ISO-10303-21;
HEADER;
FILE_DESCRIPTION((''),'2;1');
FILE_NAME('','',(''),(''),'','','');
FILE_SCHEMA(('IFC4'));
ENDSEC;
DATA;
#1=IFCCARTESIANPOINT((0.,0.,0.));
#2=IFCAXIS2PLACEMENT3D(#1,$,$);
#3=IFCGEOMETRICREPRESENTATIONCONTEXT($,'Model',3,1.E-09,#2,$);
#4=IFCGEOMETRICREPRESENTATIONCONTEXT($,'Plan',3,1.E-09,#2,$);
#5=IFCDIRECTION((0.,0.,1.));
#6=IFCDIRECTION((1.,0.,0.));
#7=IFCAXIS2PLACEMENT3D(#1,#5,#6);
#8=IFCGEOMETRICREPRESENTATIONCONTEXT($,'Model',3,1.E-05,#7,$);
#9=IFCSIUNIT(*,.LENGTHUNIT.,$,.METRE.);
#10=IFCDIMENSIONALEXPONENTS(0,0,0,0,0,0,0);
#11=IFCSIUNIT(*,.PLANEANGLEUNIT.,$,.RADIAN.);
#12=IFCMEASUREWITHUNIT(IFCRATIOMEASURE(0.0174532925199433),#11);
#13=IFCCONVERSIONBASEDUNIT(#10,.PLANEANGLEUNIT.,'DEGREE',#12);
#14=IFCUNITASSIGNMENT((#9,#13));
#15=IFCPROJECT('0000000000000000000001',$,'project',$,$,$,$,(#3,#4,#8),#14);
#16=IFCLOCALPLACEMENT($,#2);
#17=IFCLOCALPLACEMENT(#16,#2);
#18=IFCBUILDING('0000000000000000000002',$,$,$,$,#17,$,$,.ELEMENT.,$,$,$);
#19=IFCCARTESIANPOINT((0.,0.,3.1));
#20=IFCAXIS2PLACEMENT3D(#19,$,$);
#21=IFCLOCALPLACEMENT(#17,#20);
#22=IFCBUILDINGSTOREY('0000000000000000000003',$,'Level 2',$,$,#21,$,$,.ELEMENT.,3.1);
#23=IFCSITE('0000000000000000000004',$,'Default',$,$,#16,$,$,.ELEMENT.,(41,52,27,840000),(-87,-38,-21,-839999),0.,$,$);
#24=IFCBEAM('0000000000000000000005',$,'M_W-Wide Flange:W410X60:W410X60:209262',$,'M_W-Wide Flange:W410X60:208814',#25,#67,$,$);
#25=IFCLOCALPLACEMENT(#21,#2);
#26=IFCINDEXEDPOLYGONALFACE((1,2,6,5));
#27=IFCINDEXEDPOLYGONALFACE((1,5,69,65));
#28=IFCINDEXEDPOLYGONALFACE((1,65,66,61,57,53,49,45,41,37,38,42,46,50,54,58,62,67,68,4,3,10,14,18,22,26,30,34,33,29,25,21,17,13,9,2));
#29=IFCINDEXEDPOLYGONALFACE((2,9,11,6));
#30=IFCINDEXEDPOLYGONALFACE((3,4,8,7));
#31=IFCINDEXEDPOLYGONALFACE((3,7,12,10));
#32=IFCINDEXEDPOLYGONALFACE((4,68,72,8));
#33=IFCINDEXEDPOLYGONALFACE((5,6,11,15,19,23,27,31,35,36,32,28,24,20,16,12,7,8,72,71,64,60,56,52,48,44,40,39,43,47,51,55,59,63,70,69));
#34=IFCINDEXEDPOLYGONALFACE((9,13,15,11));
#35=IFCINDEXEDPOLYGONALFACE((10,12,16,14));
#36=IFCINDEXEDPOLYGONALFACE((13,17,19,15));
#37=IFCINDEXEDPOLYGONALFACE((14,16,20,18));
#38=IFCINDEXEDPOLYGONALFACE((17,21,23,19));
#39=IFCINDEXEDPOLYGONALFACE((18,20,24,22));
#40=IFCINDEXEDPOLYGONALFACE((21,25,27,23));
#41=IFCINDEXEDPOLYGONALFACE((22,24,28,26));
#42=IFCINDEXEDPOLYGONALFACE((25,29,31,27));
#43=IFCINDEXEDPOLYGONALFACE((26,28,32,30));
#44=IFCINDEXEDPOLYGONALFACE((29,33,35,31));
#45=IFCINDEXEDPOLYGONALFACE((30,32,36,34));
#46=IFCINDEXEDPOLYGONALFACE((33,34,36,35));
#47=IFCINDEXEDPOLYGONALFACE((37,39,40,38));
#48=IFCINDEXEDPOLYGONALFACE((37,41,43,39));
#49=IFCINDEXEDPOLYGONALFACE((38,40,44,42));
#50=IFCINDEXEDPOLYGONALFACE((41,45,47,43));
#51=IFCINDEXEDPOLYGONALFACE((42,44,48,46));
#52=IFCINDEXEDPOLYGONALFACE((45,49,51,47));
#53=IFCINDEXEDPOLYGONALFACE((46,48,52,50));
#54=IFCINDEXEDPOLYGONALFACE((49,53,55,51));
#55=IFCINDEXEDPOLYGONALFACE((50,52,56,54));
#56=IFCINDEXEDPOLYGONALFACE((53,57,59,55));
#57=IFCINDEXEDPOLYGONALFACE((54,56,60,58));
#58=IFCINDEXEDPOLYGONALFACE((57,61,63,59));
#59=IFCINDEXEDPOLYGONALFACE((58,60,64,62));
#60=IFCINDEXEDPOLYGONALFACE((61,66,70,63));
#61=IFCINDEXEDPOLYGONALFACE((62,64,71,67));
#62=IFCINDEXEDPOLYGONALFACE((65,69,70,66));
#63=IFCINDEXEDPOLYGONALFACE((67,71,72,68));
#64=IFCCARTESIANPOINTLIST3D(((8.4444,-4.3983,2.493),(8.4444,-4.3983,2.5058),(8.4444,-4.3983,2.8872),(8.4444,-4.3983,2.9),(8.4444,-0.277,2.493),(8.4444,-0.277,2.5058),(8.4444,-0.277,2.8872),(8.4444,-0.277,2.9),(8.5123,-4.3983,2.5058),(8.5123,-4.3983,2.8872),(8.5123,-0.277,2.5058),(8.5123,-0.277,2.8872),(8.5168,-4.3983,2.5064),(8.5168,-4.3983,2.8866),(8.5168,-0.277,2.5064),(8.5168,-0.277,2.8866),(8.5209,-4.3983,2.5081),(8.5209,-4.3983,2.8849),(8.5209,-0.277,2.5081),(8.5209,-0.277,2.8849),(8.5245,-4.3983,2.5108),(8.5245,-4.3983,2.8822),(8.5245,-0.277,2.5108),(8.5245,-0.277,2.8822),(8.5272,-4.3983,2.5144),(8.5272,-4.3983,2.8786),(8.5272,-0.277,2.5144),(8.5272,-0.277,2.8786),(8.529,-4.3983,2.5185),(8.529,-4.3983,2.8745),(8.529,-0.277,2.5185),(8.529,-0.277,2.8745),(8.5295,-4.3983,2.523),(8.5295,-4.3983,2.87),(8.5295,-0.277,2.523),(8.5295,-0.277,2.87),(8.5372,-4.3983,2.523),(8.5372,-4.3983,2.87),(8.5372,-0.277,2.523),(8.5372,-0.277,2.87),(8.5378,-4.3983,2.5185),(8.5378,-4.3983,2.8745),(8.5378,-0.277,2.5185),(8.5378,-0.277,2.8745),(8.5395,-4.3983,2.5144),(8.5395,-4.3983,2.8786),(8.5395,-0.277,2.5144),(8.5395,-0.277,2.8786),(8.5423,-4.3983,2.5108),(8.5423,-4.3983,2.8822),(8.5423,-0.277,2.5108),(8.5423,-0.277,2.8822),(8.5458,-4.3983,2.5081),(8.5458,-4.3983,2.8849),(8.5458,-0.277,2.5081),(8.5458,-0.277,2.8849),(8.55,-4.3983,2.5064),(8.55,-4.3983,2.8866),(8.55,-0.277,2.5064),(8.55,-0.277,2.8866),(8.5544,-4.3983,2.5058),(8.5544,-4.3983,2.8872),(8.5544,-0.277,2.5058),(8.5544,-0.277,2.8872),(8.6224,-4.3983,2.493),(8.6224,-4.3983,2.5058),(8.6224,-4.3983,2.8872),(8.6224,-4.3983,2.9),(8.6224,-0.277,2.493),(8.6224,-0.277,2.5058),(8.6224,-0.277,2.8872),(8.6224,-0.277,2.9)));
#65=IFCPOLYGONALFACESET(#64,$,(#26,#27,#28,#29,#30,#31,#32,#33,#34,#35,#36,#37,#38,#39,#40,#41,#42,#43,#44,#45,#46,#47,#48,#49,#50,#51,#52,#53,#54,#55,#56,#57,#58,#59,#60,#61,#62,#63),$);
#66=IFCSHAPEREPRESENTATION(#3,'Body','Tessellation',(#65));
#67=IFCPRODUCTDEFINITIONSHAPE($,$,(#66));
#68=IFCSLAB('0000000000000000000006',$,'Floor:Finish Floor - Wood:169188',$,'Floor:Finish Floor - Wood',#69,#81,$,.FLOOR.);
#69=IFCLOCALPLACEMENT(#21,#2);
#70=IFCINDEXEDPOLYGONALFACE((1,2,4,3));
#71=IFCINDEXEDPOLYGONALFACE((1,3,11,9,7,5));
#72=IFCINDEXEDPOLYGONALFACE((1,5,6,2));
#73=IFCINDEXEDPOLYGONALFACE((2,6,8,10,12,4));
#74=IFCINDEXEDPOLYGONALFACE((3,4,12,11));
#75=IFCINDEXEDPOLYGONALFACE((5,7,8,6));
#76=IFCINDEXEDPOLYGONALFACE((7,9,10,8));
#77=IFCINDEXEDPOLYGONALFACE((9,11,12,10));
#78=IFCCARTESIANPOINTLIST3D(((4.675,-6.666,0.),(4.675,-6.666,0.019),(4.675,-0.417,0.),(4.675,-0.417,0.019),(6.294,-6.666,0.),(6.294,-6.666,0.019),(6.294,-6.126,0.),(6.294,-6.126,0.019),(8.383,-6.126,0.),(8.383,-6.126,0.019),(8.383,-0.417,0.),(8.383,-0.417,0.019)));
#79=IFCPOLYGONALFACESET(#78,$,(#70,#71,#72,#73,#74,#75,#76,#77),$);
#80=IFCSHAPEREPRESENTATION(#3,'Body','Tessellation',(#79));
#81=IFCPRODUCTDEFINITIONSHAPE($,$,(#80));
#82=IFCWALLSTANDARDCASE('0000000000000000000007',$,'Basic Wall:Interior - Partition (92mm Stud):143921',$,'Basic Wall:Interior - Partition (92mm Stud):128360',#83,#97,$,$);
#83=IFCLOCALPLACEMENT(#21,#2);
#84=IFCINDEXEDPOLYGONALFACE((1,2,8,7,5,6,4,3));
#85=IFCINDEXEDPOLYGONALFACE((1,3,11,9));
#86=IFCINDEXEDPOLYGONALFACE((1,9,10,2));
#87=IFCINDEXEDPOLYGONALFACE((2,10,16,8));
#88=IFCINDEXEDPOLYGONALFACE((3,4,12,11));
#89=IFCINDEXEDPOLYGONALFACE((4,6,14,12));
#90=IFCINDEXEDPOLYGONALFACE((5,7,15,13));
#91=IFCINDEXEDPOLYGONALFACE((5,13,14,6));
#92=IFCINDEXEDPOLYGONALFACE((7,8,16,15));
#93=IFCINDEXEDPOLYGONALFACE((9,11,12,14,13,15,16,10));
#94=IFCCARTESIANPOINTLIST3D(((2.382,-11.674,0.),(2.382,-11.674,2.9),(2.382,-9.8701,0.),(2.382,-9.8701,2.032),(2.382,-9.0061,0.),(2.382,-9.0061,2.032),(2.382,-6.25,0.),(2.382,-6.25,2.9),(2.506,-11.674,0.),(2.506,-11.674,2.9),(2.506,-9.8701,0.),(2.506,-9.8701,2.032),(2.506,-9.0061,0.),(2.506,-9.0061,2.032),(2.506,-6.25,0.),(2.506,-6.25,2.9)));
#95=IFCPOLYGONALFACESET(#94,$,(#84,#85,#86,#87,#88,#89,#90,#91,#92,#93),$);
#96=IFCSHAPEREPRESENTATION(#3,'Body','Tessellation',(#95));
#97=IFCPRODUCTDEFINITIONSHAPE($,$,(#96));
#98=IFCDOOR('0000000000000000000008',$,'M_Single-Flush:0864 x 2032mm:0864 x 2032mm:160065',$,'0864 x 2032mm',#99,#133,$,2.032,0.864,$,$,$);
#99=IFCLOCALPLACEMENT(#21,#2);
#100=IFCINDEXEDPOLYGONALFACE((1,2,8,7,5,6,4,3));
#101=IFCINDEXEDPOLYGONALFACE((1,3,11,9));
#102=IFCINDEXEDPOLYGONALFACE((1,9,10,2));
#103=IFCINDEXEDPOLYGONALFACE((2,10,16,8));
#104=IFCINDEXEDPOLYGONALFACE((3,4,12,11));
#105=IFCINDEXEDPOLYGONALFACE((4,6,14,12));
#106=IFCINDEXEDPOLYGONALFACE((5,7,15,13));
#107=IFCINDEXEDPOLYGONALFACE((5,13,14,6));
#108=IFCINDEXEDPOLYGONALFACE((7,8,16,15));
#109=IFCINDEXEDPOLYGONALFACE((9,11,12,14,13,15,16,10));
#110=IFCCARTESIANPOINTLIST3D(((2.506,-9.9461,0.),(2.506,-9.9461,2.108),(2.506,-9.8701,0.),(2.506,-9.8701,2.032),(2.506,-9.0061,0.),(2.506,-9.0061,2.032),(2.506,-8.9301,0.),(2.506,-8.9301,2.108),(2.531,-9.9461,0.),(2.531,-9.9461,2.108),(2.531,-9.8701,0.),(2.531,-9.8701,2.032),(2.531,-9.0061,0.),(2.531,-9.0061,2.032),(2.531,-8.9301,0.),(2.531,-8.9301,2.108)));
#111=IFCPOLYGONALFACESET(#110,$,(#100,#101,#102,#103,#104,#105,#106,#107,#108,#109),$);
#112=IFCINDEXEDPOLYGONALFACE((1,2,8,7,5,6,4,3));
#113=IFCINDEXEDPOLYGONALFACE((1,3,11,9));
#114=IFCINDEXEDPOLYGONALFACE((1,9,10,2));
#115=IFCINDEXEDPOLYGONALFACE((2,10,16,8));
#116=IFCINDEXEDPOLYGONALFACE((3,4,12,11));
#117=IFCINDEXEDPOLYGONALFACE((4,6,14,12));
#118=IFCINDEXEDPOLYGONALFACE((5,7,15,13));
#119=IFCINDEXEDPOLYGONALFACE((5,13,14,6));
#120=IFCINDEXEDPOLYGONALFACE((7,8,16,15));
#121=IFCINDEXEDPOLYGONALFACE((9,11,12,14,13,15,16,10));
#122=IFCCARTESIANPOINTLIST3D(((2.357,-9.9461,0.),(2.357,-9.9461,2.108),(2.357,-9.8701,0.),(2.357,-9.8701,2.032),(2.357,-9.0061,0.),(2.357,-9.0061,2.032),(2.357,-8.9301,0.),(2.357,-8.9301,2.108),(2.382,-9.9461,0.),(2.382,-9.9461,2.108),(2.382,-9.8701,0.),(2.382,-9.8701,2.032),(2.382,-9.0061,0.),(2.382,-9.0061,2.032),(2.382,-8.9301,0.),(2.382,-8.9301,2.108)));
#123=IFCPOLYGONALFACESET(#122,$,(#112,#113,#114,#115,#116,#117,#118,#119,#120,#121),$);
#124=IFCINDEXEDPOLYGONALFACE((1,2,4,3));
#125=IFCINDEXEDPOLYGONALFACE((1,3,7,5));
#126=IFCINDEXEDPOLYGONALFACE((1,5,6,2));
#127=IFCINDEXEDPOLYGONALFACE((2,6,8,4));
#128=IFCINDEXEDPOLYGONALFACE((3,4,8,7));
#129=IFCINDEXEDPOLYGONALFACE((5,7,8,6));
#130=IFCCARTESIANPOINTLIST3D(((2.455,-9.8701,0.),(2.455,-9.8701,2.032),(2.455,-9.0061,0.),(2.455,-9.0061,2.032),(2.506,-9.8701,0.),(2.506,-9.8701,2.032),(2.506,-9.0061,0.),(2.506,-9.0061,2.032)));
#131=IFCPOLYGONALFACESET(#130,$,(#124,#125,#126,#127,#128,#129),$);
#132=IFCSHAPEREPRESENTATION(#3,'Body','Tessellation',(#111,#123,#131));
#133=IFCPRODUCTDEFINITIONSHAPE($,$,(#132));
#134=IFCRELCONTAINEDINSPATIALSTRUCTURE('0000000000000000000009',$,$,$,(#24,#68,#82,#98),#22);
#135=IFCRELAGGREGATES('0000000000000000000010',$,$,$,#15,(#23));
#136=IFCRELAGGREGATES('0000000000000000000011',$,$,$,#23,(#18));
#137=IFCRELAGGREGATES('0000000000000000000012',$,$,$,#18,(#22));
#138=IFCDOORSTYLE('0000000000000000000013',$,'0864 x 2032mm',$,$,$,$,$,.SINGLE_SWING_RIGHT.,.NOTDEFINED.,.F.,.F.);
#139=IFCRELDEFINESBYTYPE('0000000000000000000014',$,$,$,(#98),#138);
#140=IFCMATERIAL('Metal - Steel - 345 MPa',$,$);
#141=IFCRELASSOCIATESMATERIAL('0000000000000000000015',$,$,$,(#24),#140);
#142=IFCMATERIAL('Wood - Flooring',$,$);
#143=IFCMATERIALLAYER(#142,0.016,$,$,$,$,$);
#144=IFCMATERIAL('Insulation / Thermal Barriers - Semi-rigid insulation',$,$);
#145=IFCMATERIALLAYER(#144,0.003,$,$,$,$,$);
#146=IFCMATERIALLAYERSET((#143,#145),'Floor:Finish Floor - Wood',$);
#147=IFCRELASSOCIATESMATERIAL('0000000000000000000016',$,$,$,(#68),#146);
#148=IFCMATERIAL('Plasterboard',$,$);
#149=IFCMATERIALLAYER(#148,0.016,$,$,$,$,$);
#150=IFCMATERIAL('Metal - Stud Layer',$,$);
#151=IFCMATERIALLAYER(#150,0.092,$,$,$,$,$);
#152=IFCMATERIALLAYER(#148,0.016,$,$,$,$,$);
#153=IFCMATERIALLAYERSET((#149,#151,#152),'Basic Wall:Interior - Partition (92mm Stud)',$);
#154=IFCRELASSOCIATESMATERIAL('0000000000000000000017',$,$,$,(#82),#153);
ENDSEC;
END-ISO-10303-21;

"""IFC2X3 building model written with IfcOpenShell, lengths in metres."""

from ifc_helpers import new_model, entity, si_unit, converted_unit, frame, frame_2d, origin, origin_with_axes, origin_2d_with_axis, place, context, project, spatial, polyline, circle_curve, parameter, trimmed, segment, composite_curve, rectangle, outline, extrude, source, transform, mapped, material, layer, layer_set, layer_usage, type_object, type_shapes, element, fill, save


model = new_model("IFC2X3")

# Units and contexts
model_context_1 = context("Model", 3, precision=1e-09, world=origin())
plan_context = context("Plan", 3, precision=1e-09, world=origin())
model_context_2 = context("Model", 3, precision=1e-05, world=origin_with_axes())
ifc_project = project(units=[si_unit("LENGTHUNIT", "METRE"), converted_unit("PLANEANGLEUNIT", "DEGREE", entity("IfcRatioMeasure", 0.0174532925199433), si_unit("PLANEANGLEUNIT", "RADIAN"), dimensions=[0, 0, 0, 0, 0, 0, 0])], contexts=[model_context_1, plan_context, model_context_2])

# Site, building, storey
site_placement = place(None, origin())
site = spatial("IfcSite", under=ifc_project, at=site_placement, Name="Default", CompositionType="ELEMENT", RefLatitude=(41, 52, 27, 840000), RefLongitude=(-87, -38, -21, -839999), RefElevation=0.0)
building_placement = place(site_placement, origin())
building = spatial("IfcBuilding", under=site, at=building_placement, CompositionType="ELEMENT")
storey_placement = place(building_placement, frame((0.0, 0.0, 3.1)))
storey = spatial("IfcBuildingStorey", under=building, at=storey_placement, Name="Level 2", CompositionType="ELEMENT", Elevation=3.1)

# Beam
ifc_material_1 = material(Name="Metal - Steel - 345 MPa")
beam_1_placement = place(storey_placement, frame((8.5334, -4.3983, 2.9)))
element("IfcBeam", 1, at=beam_1_placement, inside=storey, material=ifc_material_1, Name="M_W-Wide Flange:W410X60:W410X60:209262", ObjectType="M_W-Wide Flange:W410X60:208814", context=model_context_1, shape_type="SweptSolid", body=[
    extrude(outline(composite_curve([segment(polyline([(-0.089, -0.1907), (-0.089, -0.2035)]), True, "CONTINUOUS"), segment(polyline([(-0.089, -0.2035), (0.089, -0.2035)]), True, "CONTINUOUS"), segment(polyline([(0.089, -0.2035), (0.089, -0.1907)]), True, "CONTINUOUS"), segment(polyline([(0.089, -0.1907), (0.021, -0.1907)]), True, "CONTINUOUS"), segment(trimmed(circle_curve(frame_2d((0.021, -0.1735), x_axis=(0.0, -1.0)), 0.0172), [parameter(270.0)], [parameter(360.0)], True, "PARAMETER"), False, "CONTINUOUS"), segment(polyline([(0.0038, -0.1735), (0.0038, 0.1735)]), True, "CONTINUOUS"), segment(trimmed(circle_curve(frame_2d((0.021, 0.1735), x_axis=(-1.0, 0.0)), 0.0172), [parameter(270.0)], [parameter(360.0)], True, "PARAMETER"), False, "CONTINUOUS"), segment(polyline([(0.021, 0.1907), (0.089, 0.1907)]), True, "CONTINUOUS"), segment(polyline([(0.089, 0.1907), (0.089, 0.2035)]), True, "CONTINUOUS"), segment(polyline([(0.089, 0.2035), (-0.089, 0.2035)]), True, "CONTINUOUS"), segment(polyline([(-0.089, 0.2035), (-0.089, 0.1907)]), True, "CONTINUOUS"), segment(polyline([(-0.089, 0.1907), (-0.0211, 0.1907)]), True, "CONTINUOUS"), segment(trimmed(circle_curve(frame_2d((-0.0211, 0.1735), x_axis=(0.0, 1.0)), 0.0172), [parameter(270.0)], [parameter(0.0)], True, "PARAMETER"), False, "CONTINUOUS"), segment(polyline([(-0.0039, 0.1735), (-0.0039, -0.1735)]), True, "CONTINUOUS"), segment(trimmed(circle_curve(frame_2d((-0.0211, -0.1735), x_axis=(1.0, 0.0)), 0.0172), [parameter(270.0)], [parameter(0.0)], True, "PARAMETER"), False, "CONTINUOUS"), segment(polyline([(-0.0211, -0.1907), (-0.089, -0.1907)]), True, "CONTINUOUS")], self_intersect=False)), frame((0.0, 0.0, -0.2035), z_axis=(0.0, -1.0, 0.0), x_axis=(1.0, 0.0, 0.0)), (0.0, 0.0, -1.0), 4.1213),
])

# Slab
ifc_material_2 = material(Name="Wood - Flooring")
ifc_layer_1 = layer(ifc_material_2, 0.016)
ifc_material_3 = material(Name="Insulation / Thermal Barriers - Semi-rigid insulation")
ifc_layer_2 = layer(ifc_material_3, 0.003)
ifc_layer_set_1 = layer_set([ifc_layer_1, ifc_layer_2], Name="Floor:Finish Floor - Wood")
ifc_layer_usage_1 = layer_usage(ifc_layer_set_1, "AXIS3", "POSITIVE", 0.0)
slab_placement = place(storey_placement, frame((4.675, -6.666, 0.0)))
element("IfcSlab", 2, at=slab_placement, inside=storey, material=ifc_layer_usage_1, Name="Floor:Finish Floor - Wood:169188", ObjectType="Floor:Finish Floor - Wood", PredefinedType="FLOOR", context=model_context_1, shape_type="SweptSolid", body=[
    extrude(outline(polyline([(-1.854, 3.1245), (-1.854, -2.5845), (0.235, -2.5845), (0.235, -3.1245), (1.854, -3.1245), (1.854, 3.1245), (-1.854, 3.1245)])), frame((1.854, 3.1245, 0.019), z_axis=(0.0, 0.0, -1.0), x_axis=(-1.0, 0.0, 0.0)), (0.0, 0.0, 1.0), 0.019),
])

# Shared definitions
ifc_material_4 = material(Name="Metal - Stud Layer")
ifc_material_5 = material(Name="Plasterboard")

# Wall, opening, door
ifc_layer_3 = layer(ifc_material_5, 0.016)
ifc_layer_4 = layer(ifc_material_4, 0.092)
ifc_layer_5 = layer(ifc_material_5, 0.016)
ifc_layer_set_2 = layer_set([ifc_layer_3, ifc_layer_4, ifc_layer_5], Name="Basic Wall:Interior - Partition (92mm Stud)")
ifc_layer_usage_2 = layer_usage(ifc_layer_set_2, "AXIS2", "NEGATIVE", 0.062)
wall_1_placement = place(storey_placement, frame((2.444, -6.25, 0.0), z_axis=(0.0, 0.0, 1.0), x_axis=(0.0, -1.0, 0.0)))
wall_1 = element("IfcWallStandardCase", 3, at=wall_1_placement, inside=storey, material=ifc_layer_usage_2, Name="Basic Wall:Interior - Partition (92mm Stud):143921", ObjectType="Basic Wall:Interior - Partition (92mm Stud):128360", context=model_context_1, shape_type="SweptSolid", body=[
    extrude(rectangle(XDim=5.424, YDim=0.124, at=frame_2d((2.712, 0.0), x_axis=(-1.0, 0.0))), origin(), (0.0, 0.0, 1.0), 2.9),
])
opening_1_placement = place(wall_1_placement, frame((2.7561, -0.062, 0.0)))
opening_1 = element("IfcOpeningElement", 4, at=opening_1_placement, cuts=wall_1, ObjectType="Opening", context=model_context_1, shape_type="SweptSolid", body=[
    extrude(rectangle(XDim=0.864, YDim=2.032, at=frame_2d((1.016, 0.432), x_axis=(0.0, 1.0))), frame((0.0, 0.0, 0.0), z_axis=(0.0, 1.0, 0.0), x_axis=(0.0, 0.0, 1.0)), (0.0, 0.0, 1.0), 0.124),
])
door_style_1 = type_object("IfcDoorStyle", Name="0864 x 2032mm", ConstructionType="NOTDEFINED", OperationType="SINGLE_SWING_RIGHT", ParameterTakesPrecedence=False, Sizeable=False)
shared_shape_1 = source(origin(), model_context_1, "Body", "SweptSolid", [
    extrude(outline(polyline([(-0.508, -1.073), (0.508, -1.073), (0.508, 1.035), (0.432, 1.035), (0.432, -0.997), (-0.432, -0.997), (-0.432, 1.035), (-0.508, 1.035), (-0.508, -1.073)])), frame((0.432, 0.124, 1.035), z_axis=(0.0, 1.0, 0.0), x_axis=(1.0, 0.0, 0.0)), (0.0, 0.0, 1.0), 0.025),
    extrude(outline(polyline([(-1.073, -0.508), (1.035, -0.508), (1.035, -0.432), (-0.997, -0.432), (-0.997, 0.432), (1.035, 0.432), (1.035, 0.508), (-1.073, 0.508), (-1.073, -0.508)])), frame((0.432, -0.025, 1.035), z_axis=(0.0, 1.0, 0.0), x_axis=(0.0, 0.0, -1.0)), (0.0, 0.0, 1.0), 0.025),
    extrude(rectangle(XDim=0.051, YDim=0.864, at=origin_2d_with_axis()), frame((0.432, 0.0985, 0.0), z_axis=(0.0, 0.0, 1.0), x_axis=(0.0, 1.0, 0.0)), (0.0, 0.0, 1.0), 2.032),
])
type_shapes(door_style_1, [shared_shape_1])
door_1_placement = place(opening_1_placement, origin())
door_1 = element("IfcDoor", 5, at=door_1_placement, inside=storey, type_object=door_style_1, Name="M_Single-Flush:0864 x 2032mm:0864 x 2032mm:160065", ObjectType="0864 x 2032mm", OverallHeight=2.032, OverallWidth=0.864, context=model_context_1, shape_type="MappedRepresentation", body=[
    mapped(shared_shape_1, transform((0.0, 0.0, 0.0), scale=1.0)),
])
fill(opening_1, door_1)

save(model, "model.ifc")
